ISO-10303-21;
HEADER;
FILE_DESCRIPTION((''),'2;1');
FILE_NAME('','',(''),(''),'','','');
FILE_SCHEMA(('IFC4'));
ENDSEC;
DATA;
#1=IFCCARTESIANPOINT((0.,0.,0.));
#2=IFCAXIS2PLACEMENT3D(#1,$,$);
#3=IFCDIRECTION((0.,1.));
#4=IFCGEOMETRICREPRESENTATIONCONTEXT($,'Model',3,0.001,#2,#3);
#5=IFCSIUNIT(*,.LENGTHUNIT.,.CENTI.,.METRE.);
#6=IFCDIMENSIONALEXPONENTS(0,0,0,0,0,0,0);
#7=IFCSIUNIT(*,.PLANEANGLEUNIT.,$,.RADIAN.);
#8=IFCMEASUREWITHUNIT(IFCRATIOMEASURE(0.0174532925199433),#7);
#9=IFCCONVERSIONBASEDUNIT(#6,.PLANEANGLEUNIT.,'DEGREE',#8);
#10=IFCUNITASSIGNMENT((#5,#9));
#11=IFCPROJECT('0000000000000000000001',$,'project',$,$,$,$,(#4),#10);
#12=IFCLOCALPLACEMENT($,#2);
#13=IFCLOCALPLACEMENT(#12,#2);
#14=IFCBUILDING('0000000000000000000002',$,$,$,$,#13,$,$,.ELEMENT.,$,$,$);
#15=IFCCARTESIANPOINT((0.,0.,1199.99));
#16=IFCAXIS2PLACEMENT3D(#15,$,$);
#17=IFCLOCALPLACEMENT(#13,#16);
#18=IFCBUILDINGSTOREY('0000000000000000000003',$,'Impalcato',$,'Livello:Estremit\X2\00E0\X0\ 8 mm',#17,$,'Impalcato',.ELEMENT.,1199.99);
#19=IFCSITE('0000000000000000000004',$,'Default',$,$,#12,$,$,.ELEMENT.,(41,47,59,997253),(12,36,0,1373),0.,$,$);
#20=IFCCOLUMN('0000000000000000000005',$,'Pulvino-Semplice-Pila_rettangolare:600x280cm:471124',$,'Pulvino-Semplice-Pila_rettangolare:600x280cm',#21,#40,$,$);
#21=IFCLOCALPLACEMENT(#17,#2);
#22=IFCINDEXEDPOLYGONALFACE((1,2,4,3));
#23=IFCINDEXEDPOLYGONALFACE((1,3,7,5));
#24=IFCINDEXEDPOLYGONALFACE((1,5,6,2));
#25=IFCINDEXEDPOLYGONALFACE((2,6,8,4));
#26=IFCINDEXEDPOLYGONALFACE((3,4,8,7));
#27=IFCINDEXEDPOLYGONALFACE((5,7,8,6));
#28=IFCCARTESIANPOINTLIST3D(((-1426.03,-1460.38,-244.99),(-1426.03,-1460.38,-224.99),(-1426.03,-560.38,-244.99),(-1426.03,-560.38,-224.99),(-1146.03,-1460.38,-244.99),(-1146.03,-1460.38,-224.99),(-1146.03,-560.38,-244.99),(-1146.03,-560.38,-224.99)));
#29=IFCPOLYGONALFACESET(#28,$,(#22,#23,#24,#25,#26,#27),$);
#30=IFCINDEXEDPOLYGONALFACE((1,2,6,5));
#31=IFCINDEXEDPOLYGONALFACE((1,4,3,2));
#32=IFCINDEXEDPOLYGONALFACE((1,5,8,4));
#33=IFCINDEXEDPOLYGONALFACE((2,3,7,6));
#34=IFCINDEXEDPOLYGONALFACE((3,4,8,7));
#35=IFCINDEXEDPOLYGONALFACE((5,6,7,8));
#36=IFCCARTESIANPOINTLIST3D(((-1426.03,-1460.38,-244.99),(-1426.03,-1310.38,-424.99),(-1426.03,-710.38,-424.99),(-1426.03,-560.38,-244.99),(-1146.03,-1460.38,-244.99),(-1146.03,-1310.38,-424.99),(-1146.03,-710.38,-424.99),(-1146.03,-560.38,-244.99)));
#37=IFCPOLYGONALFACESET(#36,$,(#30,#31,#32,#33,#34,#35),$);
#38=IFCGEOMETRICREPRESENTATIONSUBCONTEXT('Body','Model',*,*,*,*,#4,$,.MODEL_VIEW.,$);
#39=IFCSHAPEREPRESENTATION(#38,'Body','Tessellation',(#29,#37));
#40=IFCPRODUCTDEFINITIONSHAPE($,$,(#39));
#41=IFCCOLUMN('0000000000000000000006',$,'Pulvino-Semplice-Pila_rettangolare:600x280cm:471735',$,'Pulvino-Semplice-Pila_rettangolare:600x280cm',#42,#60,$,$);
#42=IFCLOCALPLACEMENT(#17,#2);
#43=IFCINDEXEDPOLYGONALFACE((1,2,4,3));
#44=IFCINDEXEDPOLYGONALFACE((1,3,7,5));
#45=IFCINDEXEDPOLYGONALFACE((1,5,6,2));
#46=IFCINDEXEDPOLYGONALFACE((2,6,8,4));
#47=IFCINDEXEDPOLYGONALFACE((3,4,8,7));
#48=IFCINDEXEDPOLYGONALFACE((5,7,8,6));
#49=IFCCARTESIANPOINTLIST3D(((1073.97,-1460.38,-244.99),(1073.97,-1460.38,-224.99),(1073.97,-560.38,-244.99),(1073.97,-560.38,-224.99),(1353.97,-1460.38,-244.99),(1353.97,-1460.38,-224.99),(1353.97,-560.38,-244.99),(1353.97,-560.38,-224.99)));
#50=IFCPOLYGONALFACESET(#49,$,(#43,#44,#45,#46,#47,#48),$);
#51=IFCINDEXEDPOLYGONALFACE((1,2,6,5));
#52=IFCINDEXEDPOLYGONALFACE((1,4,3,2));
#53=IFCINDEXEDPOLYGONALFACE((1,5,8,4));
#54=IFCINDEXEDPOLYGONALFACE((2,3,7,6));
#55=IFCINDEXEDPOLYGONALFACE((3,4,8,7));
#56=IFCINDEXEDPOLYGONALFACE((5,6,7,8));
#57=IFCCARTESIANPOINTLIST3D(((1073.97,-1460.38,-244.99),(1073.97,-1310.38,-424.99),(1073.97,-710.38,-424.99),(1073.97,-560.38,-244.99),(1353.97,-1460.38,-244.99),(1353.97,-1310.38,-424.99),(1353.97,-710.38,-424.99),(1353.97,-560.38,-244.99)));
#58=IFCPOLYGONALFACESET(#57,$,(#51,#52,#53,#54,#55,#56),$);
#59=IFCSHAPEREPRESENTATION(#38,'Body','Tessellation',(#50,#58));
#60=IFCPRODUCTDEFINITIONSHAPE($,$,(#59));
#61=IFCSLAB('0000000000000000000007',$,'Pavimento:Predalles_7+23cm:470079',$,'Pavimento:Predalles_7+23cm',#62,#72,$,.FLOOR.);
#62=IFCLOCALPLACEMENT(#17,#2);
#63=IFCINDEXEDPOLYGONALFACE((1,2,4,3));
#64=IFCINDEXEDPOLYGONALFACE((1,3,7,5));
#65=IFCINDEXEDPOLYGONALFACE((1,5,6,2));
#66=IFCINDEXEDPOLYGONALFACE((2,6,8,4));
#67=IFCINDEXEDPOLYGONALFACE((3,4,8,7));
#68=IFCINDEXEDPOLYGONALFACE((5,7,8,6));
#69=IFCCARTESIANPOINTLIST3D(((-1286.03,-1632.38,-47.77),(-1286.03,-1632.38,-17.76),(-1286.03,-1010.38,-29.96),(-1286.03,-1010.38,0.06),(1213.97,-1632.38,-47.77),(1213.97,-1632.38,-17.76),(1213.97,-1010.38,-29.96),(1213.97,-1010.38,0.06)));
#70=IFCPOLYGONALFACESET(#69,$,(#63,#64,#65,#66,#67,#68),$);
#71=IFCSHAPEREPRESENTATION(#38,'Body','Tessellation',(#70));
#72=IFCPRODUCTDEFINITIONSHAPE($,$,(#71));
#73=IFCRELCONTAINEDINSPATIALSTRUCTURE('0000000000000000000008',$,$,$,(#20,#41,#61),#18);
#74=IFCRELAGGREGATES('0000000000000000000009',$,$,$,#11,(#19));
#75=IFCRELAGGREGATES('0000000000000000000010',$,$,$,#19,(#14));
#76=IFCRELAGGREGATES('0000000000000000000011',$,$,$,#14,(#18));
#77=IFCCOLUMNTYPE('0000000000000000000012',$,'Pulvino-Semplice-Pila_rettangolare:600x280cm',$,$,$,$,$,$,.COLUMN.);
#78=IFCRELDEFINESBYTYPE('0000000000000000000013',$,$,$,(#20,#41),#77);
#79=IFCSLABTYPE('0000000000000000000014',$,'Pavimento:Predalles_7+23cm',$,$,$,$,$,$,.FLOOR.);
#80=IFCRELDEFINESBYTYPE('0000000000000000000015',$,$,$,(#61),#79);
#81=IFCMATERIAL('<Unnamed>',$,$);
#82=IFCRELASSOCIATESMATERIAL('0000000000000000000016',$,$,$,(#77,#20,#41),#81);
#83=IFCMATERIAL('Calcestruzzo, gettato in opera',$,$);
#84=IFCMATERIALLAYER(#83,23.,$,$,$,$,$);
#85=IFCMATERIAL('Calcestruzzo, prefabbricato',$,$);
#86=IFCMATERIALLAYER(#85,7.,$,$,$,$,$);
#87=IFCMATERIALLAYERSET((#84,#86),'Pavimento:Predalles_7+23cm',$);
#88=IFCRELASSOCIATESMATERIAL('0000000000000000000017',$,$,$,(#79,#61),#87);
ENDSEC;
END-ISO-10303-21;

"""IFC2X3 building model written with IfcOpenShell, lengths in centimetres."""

from ifc_helpers import new_model, entity, si_unit, converted_unit, direction, frame, frame_2d, origin, place, context, subcontext, project, spatial, rectangle, extrude, clip, halfspace, source, transform, mapped, material, layer, layer_set, layer_usage, type_object, type_shapes, element, save


model = new_model("IFC2X3")

# Units and contexts
model_context = context("Model", 3, precision=0.001, world=origin(), true_north=direction((0.0, 1.0)))
body_context = subcontext(model_context, "Body", "Model", "MODEL_VIEW")
ifc_project = project(units=[si_unit("LENGTHUNIT", "METRE", prefix="CENTI"), converted_unit("PLANEANGLEUNIT", "DEGREE", entity("IfcRatioMeasure", 0.0174532925199433), si_unit("PLANEANGLEUNIT", "RADIAN"), dimensions=[0, 0, 0, 0, 0, 0, 0])], contexts=[model_context])

# Site, building, storey
site_placement = place(None, origin())
site = spatial("IfcSite", under=ifc_project, at=site_placement, Name="Default", CompositionType="ELEMENT", RefLatitude=(41, 47, 59, 997253), RefLongitude=(12, 36, 0, 1373), RefElevation=0.0)
building_placement = place(site_placement, origin())
building = spatial("IfcBuilding", under=site, at=building_placement, CompositionType="ELEMENT")
storey_placement = place(building_placement, frame((0.0, 0.0, 1199.99)))
storey = spatial("IfcBuildingStorey", under=building, at=storey_placement, Name="Impalcato", ObjectType="Livello:Estremità 8 mm", LongName="Impalcato", CompositionType="ELEMENT", Elevation=1199.99)

# Columns
ifc_material_1 = material(Name="<Unnamed>")
column_type = type_object("IfcColumnType", Name="Pulvino-Semplice-Pila_rettangolare:600x280cm", PredefinedType="COLUMN", material=ifc_material_1)
shared_shape = source(origin(), body_context, "Body", "SweptSolid", [
    extrude(rectangle(XDim=900.0, YDim=280.0, at=frame_2d((0.0, 0.0), x_axis=(1.0, 0.0))), frame((0.0, 0.0, 180.0), z_axis=(0.0, 0.0, 1.0), x_axis=(0.0, -1.0, 0.0)), (0.0, 0.0, 1.0), 20.0),
    clip(clip(extrude(rectangle(XDim=280.0, YDim=900.0, at=frame_2d((0.0, 0.0), x_axis=(1.0, 0.0))), origin(), (0.0, 0.0, 1.0), 180.0), halfspace(frame((0.0, -300.0, 0.0), z_axis=(0.0, -0.768221, -0.640184), x_axis=(1.0, 0.0, 0.0)), False)), halfspace(frame((0.0, 300.0, 0.0), z_axis=(0.0, 0.768221, -0.640184), x_axis=(-1.0, 0.0, 0.0)), False)),
])
type_shapes(column_type, [shared_shape])
for number, where, name in (
    (1, (-1286.03, -1010.38, -424.99), "Pulvino-Semplice-Pila_rettangolare:600x280cm:471124"),
    (2, (1213.97, -1010.38, -424.99), "Pulvino-Semplice-Pila_rettangolare:600x280cm:471735"),
):
    element("IfcColumn", number, at=place(storey_placement, frame(where)), inside=storey, type_object=column_type, material=ifc_material_1, Name=name, ObjectType="Pulvino-Semplice-Pila_rettangolare:600x280cm", context=body_context, shape_type="MappedRepresentation", body=[
        mapped(shared_shape, transform((0.0, 0.0, 0.0), scale=1.0)),
    ])

# Slab
ifc_material_2 = material(Name="Calcestruzzo, gettato in opera")
ifc_layer_1 = layer(ifc_material_2, 23.0)
ifc_material_3 = material(Name="Calcestruzzo, prefabbricato")
ifc_layer_2 = layer(ifc_material_3, 7.0)
ifc_layer_set = layer_set([ifc_layer_1, ifc_layer_2], Name="Pavimento:Predalles_7+23cm")
ifc_layer_usage_1 = layer_usage(ifc_layer_set, "AXIS3", "POSITIVE", 0.0)
slab_type_1 = type_object("IfcSlabType", Name="Pavimento:Predalles_7+23cm", PredefinedType="FLOOR", material=ifc_layer_set)
slab_1_placement = place(storey_placement, origin())
element("IfcSlab", 3, at=slab_1_placement, inside=storey, type_object=slab_type_1, material=ifc_layer_usage_1, Name="Pavimento:Predalles_7+23cm:470079", ObjectType="Pavimento:Predalles_7+23cm", PredefinedType="FLOOR", context=body_context, shape_type="SweptSolid", body=[
    clip(clip(extrude(rectangle(XDim=622.26, YDim=2500.0, at=frame_2d((0.0, 0.0), x_axis=(1.0, 0.0))), frame((-36.03, -1321.38, -8.85), z_axis=(0.0, 0.028633, -0.99959), x_axis=(0.0, 0.99959, 0.028633)), (-0.028633, 0.0, 0.99959), 30.02), halfspace(frame((-36.03, -1632.38, -47.77), z_axis=(0.0, 0.028633, -0.99959), x_axis=(0.0, 0.99959, 0.028633)), False)), halfspace(frame((-36.03, -1632.38, -17.76), z_axis=(0.0, -0.028633, 0.99959), x_axis=(0.0, -0.99959, -0.028633)), False)),
])

save(model, "model.ifc")
